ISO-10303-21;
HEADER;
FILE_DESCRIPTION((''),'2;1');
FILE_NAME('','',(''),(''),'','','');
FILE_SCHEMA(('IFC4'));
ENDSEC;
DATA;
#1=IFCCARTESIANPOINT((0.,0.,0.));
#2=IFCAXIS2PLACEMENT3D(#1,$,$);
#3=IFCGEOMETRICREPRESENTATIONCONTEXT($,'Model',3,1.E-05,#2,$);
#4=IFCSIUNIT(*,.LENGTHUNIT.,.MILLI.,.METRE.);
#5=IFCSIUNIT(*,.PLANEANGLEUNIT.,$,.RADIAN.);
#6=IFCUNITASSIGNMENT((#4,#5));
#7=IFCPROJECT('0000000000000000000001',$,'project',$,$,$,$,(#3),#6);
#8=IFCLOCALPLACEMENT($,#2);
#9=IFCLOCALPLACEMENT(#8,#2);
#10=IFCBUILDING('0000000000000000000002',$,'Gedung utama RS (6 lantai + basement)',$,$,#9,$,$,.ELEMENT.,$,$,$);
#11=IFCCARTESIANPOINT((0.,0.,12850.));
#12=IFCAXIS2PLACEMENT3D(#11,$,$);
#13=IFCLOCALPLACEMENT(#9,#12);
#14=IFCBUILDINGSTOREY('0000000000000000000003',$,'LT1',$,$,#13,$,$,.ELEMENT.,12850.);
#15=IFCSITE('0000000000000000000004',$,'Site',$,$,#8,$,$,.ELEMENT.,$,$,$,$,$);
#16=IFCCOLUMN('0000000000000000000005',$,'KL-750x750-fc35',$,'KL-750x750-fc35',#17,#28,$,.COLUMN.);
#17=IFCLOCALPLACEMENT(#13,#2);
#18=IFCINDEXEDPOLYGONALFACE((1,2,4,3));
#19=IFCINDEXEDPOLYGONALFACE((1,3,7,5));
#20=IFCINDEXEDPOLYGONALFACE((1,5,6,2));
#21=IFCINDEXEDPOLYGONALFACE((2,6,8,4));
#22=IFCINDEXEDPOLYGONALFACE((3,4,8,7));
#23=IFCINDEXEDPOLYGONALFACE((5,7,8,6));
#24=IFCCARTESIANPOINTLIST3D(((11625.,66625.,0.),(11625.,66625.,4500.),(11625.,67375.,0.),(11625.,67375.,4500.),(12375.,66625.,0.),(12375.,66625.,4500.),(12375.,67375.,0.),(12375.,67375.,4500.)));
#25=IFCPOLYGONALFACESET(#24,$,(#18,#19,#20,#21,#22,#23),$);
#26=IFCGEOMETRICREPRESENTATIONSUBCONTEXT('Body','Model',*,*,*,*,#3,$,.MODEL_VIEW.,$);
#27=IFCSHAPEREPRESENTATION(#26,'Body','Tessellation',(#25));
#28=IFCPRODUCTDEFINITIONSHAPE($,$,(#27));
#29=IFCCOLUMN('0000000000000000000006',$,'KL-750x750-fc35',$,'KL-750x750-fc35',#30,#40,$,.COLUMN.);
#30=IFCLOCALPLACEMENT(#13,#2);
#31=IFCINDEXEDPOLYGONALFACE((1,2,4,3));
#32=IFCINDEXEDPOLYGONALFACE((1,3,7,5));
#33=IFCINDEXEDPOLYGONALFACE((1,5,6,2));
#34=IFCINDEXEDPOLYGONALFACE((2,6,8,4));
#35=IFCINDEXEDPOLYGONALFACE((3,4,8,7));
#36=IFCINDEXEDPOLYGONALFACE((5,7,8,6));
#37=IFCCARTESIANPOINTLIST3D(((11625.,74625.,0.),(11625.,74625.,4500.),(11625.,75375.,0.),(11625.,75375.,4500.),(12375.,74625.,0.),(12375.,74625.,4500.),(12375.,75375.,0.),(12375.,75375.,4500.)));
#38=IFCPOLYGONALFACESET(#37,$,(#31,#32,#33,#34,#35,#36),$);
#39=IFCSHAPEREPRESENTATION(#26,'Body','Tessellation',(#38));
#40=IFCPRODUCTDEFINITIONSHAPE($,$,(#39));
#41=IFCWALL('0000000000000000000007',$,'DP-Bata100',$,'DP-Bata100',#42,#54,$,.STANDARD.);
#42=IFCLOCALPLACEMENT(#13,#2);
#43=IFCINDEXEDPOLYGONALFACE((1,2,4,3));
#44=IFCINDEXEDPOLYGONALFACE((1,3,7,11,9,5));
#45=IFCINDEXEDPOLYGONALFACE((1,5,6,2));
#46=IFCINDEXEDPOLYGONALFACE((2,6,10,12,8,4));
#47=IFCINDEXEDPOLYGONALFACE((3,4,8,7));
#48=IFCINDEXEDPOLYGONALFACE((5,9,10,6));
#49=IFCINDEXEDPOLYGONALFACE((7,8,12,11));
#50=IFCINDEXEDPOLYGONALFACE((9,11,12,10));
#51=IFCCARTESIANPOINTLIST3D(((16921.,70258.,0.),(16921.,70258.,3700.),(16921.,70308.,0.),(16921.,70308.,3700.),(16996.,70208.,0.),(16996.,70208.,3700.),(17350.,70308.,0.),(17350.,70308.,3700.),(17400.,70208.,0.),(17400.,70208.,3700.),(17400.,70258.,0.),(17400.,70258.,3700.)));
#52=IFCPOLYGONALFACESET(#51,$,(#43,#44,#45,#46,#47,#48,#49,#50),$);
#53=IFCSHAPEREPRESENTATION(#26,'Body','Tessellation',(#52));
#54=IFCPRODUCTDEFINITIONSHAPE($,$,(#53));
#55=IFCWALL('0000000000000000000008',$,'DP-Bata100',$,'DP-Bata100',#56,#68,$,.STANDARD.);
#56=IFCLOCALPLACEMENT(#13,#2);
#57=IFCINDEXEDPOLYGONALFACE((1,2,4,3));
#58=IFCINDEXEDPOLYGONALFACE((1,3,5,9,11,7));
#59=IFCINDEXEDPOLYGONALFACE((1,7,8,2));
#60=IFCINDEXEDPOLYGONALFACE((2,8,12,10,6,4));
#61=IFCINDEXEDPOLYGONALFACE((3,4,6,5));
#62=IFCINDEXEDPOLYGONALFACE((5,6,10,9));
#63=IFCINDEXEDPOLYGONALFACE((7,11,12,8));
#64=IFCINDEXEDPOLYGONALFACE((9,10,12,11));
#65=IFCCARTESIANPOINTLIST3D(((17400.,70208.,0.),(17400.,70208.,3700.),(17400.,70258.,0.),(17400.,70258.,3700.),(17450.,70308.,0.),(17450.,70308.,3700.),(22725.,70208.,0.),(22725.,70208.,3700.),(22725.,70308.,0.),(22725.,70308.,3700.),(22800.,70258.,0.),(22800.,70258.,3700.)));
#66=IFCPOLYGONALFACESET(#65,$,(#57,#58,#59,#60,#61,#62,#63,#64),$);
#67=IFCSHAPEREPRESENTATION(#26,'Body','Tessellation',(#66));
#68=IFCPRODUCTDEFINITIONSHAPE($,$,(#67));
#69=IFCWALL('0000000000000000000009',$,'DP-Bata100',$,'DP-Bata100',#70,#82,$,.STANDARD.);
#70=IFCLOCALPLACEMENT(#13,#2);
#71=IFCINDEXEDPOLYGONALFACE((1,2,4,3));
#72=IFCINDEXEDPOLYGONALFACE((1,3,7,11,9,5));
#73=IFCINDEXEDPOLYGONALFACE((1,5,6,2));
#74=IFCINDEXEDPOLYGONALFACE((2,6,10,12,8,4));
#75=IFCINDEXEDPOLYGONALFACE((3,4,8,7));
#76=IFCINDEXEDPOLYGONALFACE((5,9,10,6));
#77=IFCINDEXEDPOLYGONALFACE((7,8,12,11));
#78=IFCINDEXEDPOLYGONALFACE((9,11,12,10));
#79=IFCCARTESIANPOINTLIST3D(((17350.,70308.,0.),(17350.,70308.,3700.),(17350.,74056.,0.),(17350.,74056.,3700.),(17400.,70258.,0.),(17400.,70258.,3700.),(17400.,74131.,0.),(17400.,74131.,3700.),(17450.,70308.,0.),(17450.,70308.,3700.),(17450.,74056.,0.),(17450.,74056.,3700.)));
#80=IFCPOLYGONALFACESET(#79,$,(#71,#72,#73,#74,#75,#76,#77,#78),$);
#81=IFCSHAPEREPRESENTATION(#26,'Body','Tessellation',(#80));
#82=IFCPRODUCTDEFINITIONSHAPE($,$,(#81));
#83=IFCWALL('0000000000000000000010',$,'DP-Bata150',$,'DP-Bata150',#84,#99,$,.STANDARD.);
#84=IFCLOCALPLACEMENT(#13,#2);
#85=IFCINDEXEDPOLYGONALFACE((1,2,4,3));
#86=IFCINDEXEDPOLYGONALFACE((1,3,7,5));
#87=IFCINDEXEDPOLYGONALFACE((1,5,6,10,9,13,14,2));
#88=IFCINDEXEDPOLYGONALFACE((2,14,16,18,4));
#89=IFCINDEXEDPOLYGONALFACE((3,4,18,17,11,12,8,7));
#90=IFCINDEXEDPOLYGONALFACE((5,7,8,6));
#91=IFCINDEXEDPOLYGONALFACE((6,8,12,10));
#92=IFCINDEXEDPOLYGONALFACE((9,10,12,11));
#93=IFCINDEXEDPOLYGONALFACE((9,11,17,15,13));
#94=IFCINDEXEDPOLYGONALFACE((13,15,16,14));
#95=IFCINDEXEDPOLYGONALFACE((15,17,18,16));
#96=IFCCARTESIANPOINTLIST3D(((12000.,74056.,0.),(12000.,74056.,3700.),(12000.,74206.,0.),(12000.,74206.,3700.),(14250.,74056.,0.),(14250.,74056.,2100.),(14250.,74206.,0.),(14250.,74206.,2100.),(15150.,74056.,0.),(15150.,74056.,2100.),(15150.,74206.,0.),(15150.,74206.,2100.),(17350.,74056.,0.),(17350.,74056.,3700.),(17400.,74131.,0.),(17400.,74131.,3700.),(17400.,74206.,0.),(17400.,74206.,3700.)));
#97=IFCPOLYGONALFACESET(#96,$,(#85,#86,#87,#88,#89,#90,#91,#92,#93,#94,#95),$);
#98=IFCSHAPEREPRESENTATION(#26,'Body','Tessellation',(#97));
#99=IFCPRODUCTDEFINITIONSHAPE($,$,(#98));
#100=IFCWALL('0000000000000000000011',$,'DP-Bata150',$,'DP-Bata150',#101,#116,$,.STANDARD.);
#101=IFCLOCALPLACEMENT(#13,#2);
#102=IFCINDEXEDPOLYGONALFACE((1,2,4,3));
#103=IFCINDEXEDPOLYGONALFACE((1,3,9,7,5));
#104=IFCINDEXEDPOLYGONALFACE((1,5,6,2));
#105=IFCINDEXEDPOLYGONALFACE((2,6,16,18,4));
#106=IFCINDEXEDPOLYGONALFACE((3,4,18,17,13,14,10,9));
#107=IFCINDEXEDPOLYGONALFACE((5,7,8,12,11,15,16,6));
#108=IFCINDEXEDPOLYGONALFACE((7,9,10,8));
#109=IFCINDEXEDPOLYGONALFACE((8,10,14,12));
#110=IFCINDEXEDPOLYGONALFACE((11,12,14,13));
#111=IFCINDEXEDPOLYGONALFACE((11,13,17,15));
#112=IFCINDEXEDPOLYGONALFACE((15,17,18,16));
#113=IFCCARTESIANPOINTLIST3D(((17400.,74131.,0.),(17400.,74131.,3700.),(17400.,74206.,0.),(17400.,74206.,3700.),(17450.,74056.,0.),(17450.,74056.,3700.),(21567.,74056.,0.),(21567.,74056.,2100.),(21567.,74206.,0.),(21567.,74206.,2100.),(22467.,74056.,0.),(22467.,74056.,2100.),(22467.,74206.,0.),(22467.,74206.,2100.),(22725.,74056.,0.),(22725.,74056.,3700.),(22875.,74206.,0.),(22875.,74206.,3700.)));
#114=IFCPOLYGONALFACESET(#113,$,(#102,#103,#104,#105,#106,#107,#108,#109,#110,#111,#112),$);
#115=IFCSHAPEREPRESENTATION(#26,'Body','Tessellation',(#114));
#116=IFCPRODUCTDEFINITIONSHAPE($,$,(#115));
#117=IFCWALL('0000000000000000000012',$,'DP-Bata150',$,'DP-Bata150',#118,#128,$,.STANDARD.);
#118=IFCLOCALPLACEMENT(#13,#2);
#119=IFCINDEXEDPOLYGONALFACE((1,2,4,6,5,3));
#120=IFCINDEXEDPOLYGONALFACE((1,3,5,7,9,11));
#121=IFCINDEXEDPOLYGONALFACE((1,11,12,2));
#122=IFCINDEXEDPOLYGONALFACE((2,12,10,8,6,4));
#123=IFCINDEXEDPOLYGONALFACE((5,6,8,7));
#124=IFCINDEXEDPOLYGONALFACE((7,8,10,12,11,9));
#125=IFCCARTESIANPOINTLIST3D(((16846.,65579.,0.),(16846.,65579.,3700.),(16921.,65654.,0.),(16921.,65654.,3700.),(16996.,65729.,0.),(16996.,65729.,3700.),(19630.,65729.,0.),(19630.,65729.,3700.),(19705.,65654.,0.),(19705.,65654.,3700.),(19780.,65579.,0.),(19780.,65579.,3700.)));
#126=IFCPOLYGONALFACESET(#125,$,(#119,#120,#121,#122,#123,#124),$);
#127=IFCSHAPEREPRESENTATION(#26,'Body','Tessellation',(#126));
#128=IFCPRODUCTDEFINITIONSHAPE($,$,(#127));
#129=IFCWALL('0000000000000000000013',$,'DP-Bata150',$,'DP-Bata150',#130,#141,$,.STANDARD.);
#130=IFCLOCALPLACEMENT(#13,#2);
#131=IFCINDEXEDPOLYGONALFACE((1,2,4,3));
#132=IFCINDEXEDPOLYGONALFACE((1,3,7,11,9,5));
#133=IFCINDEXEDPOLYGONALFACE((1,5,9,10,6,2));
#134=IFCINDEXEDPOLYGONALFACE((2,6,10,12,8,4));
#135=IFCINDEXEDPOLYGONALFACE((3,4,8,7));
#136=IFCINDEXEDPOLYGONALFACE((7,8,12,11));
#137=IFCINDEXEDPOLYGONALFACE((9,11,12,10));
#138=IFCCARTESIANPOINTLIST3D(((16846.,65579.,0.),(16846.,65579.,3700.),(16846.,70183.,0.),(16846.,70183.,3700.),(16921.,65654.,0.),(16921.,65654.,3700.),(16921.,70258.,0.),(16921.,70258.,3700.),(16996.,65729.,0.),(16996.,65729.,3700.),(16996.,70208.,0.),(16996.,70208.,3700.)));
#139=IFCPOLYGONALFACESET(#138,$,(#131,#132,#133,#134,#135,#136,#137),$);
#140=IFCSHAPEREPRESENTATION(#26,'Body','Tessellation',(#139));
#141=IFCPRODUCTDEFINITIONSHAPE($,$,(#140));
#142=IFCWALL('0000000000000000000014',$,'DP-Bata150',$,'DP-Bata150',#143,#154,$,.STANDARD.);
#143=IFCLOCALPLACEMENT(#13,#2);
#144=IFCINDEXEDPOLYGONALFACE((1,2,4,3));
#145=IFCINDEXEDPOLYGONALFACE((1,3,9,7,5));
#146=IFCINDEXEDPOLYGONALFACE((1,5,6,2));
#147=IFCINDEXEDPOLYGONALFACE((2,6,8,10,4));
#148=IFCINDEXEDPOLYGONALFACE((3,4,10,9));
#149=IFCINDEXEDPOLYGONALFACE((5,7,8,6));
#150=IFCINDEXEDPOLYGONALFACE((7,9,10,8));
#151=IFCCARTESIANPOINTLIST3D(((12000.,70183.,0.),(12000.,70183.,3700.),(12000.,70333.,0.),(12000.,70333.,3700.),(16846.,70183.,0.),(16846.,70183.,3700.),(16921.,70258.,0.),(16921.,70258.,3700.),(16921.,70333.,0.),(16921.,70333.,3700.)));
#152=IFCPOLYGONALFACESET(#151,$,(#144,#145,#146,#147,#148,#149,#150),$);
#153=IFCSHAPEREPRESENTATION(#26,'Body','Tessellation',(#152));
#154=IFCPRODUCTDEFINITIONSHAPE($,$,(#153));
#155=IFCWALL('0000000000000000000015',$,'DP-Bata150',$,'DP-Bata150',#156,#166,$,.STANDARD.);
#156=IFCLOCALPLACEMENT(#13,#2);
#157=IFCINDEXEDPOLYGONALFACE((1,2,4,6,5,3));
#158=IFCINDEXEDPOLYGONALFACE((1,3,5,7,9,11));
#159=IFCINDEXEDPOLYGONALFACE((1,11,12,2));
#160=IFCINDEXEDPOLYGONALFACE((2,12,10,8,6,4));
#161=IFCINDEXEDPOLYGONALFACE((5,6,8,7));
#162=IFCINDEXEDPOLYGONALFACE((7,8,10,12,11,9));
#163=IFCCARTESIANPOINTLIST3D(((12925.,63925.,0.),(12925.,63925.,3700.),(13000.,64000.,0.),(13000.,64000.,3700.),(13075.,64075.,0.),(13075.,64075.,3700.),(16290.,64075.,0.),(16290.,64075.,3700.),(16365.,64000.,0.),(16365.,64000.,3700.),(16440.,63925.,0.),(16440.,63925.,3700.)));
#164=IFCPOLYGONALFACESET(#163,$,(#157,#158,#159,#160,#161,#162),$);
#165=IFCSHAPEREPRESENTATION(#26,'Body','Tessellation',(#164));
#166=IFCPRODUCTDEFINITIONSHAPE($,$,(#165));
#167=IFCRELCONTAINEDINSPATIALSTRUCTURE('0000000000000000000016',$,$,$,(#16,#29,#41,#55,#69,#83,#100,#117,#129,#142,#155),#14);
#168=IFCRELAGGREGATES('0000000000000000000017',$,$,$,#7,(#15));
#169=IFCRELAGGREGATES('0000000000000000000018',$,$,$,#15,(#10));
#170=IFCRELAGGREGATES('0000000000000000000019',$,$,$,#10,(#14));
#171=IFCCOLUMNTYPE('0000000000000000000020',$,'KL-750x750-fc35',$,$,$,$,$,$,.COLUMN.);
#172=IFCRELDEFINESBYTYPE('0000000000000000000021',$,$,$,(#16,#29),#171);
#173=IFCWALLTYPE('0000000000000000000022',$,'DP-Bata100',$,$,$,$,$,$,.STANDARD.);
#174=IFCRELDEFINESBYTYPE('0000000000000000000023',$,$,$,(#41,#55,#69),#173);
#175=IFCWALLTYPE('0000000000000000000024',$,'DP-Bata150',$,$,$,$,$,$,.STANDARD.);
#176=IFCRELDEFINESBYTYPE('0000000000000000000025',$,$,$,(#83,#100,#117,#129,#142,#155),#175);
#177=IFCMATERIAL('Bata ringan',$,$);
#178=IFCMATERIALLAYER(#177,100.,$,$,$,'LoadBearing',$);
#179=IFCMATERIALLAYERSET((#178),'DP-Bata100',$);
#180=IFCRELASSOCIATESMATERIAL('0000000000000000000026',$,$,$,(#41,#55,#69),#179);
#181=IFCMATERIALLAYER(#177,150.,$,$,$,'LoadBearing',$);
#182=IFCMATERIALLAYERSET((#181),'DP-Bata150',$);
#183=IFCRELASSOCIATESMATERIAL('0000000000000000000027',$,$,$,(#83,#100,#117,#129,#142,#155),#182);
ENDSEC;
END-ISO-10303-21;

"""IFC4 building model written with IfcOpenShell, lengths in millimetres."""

from ifc_helpers import new_model, si_unit, frame, frame_2d, origin, origin_2d, place, context, subcontext, project, spatial, polyline, rectangle, outline, extrude, material, layer, layer_set, layer_usage, material_profile, profile_set, profile_usage, type_object, element, save


model = new_model("IFC4")

# Units and contexts
model_context = context("Model", 3, precision=1e-05, world=origin())
body_context = subcontext(model_context, "Body", "Model", "MODEL_VIEW")
ifc_project = project(units=[si_unit("LENGTHUNIT", "METRE", prefix="MILLI"), si_unit("PLANEANGLEUNIT", "RADIAN")], contexts=[model_context])

# Site, building, storey
site_placement = place(None, origin())
site = spatial("IfcSite", under=ifc_project, at=site_placement, Name="Site", CompositionType="ELEMENT")
building_placement = place(site_placement, origin())
building = spatial("IfcBuilding", under=site, at=building_placement, Name="Gedung utama RS (6 lantai + basement)", CompositionType="ELEMENT")
storey_placement = place(building_placement, frame((0.0, 0.0, 12850.0)))
storey = spatial("IfcBuildingStorey", under=building, at=storey_placement, Name="LT1", CompositionType="ELEMENT", Elevation=12850.0)

# Columns
ifc_material_profile = material_profile(None, rectangle(XDim=750.0, YDim=750.0, at=origin_2d()), Name="KL-750x750-fc35")
ifc_profile_set = profile_set([ifc_material_profile], Name="KL-750x750-fc35")
ifc_profile_usage = profile_usage(ifc_profile_set, cardinal=5)
column_type = type_object("IfcColumnType", Name="KL-750x750-fc35", PredefinedType="COLUMN")
for number, where, z_axis, x_axis, name in (
    (1, (12000.0, 67000.0, 0.0), (0.0, 0.0, 1.0), (1.0, 0.0, 0.0), "KL-750x750-fc35"),
    (2, (12000.0, 75000.0, 0.0), (0.0, 0.0, 1.0), (1.0, 0.0, 0.0), "KL-750x750-fc35"),
):
    element("IfcColumn", number, at=place(storey_placement, frame(where, z_axis=z_axis, x_axis=x_axis)), inside=storey, type_object=column_type, material=ifc_profile_usage, Name=name, ObjectType="KL-750x750-fc35", PredefinedType="COLUMN", context=body_context, shape_type="SweptSolid", body=[
        extrude(rectangle(XDim=750.0, YDim=750.0, at=origin_2d()), origin(), (0.0, 0.0, 1.0), 4500.0),
    ])

# Walls
ifc_material_1 = material(Name="Bata ringan")
ifc_layer_1 = layer(ifc_material_1, 100.0, Category="LoadBearing")
ifc_layer_set_1 = layer_set([ifc_layer_1], Name="DP-Bata100")
ifc_layer_usage_1 = layer_usage(ifc_layer_set_1, "AXIS2", "NEGATIVE", 50.0)
wall_type_1 = type_object("IfcWallType", Name="DP-Bata100", PredefinedType="STANDARD")
wall_1_placement = place(storey_placement, frame((16921.0, 70258.0, 0.0), z_axis=(0.0, 0.0, 1.0), x_axis=(1.0, 0.0, 0.0)))
element("IfcWall", 3, at=wall_1_placement, inside=storey, type_object=wall_type_1, material=ifc_layer_usage_1, Name="DP-Bata100", ObjectType="DP-Bata100", PredefinedType="STANDARD", context=body_context, shape_type="SweptSolid", body=[
    extrude(outline(polyline([(75.0, -50.0), (0.0, 0.0), (0.0, 50.0), (429.0, 50.0), (479.0, 0.0), (479.0, -50.0), (75.0, -50.0)])), origin(), (0.0, 0.0, 1.0), 3700.0),
])
wall_2_placement = place(storey_placement, frame((17400.0, 70258.0, 0.0), z_axis=(0.0, 0.0, 1.0), x_axis=(1.0, 0.0, 0.0)))
element("IfcWall", 4, at=wall_2_placement, inside=storey, type_object=wall_type_1, material=ifc_layer_usage_1, Name="DP-Bata100", ObjectType="DP-Bata100", PredefinedType="STANDARD", context=body_context, shape_type="SweptSolid", body=[
    extrude(outline(polyline([(0.0, -50.0), (0.0, 0.0), (50.0, 50.0), (5325.0, 50.0), (5400.0, 0.0), (5325.0, -50.0), (0.0, -50.0)])), origin(), (0.0, 0.0, 1.0), 3700.0),
])
wall_3_placement = place(storey_placement, frame((17400.0, 74131.0, 0.0), z_axis=(0.0, 0.0, 1.0), x_axis=(0.0, -1.0, 0.0)))
element("IfcWall", 5, at=wall_3_placement, inside=storey, type_object=wall_type_1, material=ifc_layer_usage_1, Name="DP-Bata100", ObjectType="DP-Bata100", PredefinedType="STANDARD", context=body_context, shape_type="SweptSolid", body=[
    extrude(outline(polyline([(75.0, -50.0), (0.0, 0.0), (75.0, 50.0), (3823.0, 50.0), (3873.0, 0.0), (3823.0, -50.0), (75.0, -50.0)])), origin(), (0.0, 0.0, 1.0), 3700.0),
])

# Walls, openings
ifc_layer_2 = layer(ifc_material_1, 150.0, Category="LoadBearing")
ifc_layer_set_2 = layer_set([ifc_layer_2], Name="DP-Bata150")
ifc_layer_usage_2 = layer_usage(ifc_layer_set_2, "AXIS2", "NEGATIVE", 75.0)
wall_type_2 = type_object("IfcWallType", Name="DP-Bata150", PredefinedType="STANDARD")
wall_4_placement = place(storey_placement, frame((12000.0, 74131.0, 0.0), z_axis=(0.0, 0.0, 1.0), x_axis=(1.0, 0.0, 0.0)))
wall_4 = element("IfcWall", 6, at=wall_4_placement, inside=storey, type_object=wall_type_2, material=ifc_layer_usage_2, Name="DP-Bata150", ObjectType="DP-Bata150", PredefinedType="STANDARD", context=body_context, shape_type="SweptSolid", body=[
    extrude(outline(polyline([(0.0, -75.0), (0.0, 75.0), (5400.0, 75.0), (5400.0, 0.0), (5350.0, -75.0), (0.0, -75.0)])), origin(), (0.0, 0.0, 1.0), 3700.0),
])
opening_1_placement = place(wall_4_placement, frame((2250.0, 0.0, 0.0), z_axis=(0.0, 0.0, 1.0), x_axis=(1.0, 0.0, 0.0)))
element("IfcOpeningElement", 7, at=opening_1_placement, cuts=wall_4, PredefinedType="OPENING", context=body_context, shape_type="SweptSolid", body=[
    extrude(rectangle(XDim=900.0, YDim=170.0, at=frame_2d((450.0, 0.0))), origin(), (0.0, 0.0, 1.0), 2100.0),
])
wall_5_placement = place(storey_placement, frame((17400.0, 74131.0, 0.0), z_axis=(0.0, 0.0, 1.0), x_axis=(1.0, 0.0, 0.0)))
wall_5 = element("IfcWall", 8, at=wall_5_placement, inside=storey, type_object=wall_type_2, material=ifc_layer_usage_2, Name="DP-Bata150", ObjectType="DP-Bata150", PredefinedType="STANDARD", context=body_context, shape_type="SweptSolid", body=[
    extrude(outline(polyline([(50.0, -75.0), (0.0, 0.0), (0.0, 75.0), (5475.0, 75.0), (5400.0, 0.0), (5325.0, -75.0), (50.0, -75.0)])), origin(), (0.0, 0.0, 1.0), 3700.0),
])
opening_2_placement = place(wall_5_placement, frame((4167.0, 0.0, 0.0), z_axis=(0.0, 0.0, 1.0), x_axis=(1.0, 0.0, 0.0)))
element("IfcOpeningElement", 9, at=opening_2_placement, cuts=wall_5, PredefinedType="OPENING", context=body_context, shape_type="SweptSolid", body=[
    extrude(rectangle(XDim=900.0, YDim=170.0, at=frame_2d((450.0, 0.0))), origin(), (0.0, 0.0, 1.0), 2100.0),
])

# Walls
wall_6_placement = place(storey_placement, frame((19705.0, 65654.0, 0.0), z_axis=(0.0, 0.0, 1.0), x_axis=(-1.0, 0.0, 0.0)))
element("IfcWall", 10, at=wall_6_placement, inside=storey, type_object=wall_type_2, material=ifc_layer_usage_2, Name="DP-Bata150", ObjectType="DP-Bata150", PredefinedType="STANDARD", context=body_context, shape_type="SweptSolid", body=[
    extrude(outline(polyline([(75.0, -75.0), (0.0, 0.0), (-75.0, 75.0), (2859.0, 75.0), (2784.0, 0.0), (2709.0, -75.0), (75.0, -75.0)])), origin(), (0.0, 0.0, 1.0), 3700.0),
])
wall_7_placement = place(storey_placement, frame((16921.0, 65654.0, 0.0), z_axis=(0.0, 0.0, 1.0), x_axis=(0.0, 1.0, 0.0)))
element("IfcWall", 11, at=wall_7_placement, inside=storey, type_object=wall_type_2, material=ifc_layer_usage_2, Name="DP-Bata150", ObjectType="DP-Bata150", PredefinedType="STANDARD", context=body_context, shape_type="SweptSolid", body=[
    extrude(outline(polyline([(75.0, -75.0), (0.0, 0.0), (-75.0, 75.0), (4529.0, 75.0), (4604.0, 0.0), (4554.0, -75.0), (75.0, -75.0)])), origin(), (0.0, 0.0, 1.0), 3700.0),
])
wall_8_placement = place(storey_placement, frame((16921.0, 70258.0, 0.0), z_axis=(0.0, 0.0, 1.0), x_axis=(-1.0, 0.0, 0.0)))
element("IfcWall", 12, at=wall_8_placement, inside=storey, type_object=wall_type_2, material=ifc_layer_usage_2, Name="DP-Bata150", ObjectType="DP-Bata150", PredefinedType="STANDARD", context=body_context, shape_type="SweptSolid", body=[
    extrude(outline(polyline([(0.0, -75.0), (0.0, 0.0), (75.0, 75.0), (4921.0, 75.0), (4921.0, -75.0), (0.0, -75.0)])), origin(), (0.0, 0.0, 1.0), 3700.0),
])
wall_9_placement = place(storey_placement, frame((13000.0, 64000.0, 0.0), z_axis=(0.0, 0.0, 1.0), x_axis=(1.0, 0.0, 0.0)))
element("IfcWall", 13, at=wall_9_placement, inside=storey, type_object=wall_type_2, material=ifc_layer_usage_2, Name="DP-Bata150", ObjectType="DP-Bata150", PredefinedType="STANDARD", context=body_context, shape_type="SweptSolid", body=[
    extrude(outline(polyline([(-75.0, -75.0), (0.0, 0.0), (75.0, 75.0), (3290.0, 75.0), (3365.0, 0.0), (3440.0, -75.0), (-75.0, -75.0)])), origin(), (0.0, 0.0, 1.0), 3700.0),
])

save(model, "model.ifc")
